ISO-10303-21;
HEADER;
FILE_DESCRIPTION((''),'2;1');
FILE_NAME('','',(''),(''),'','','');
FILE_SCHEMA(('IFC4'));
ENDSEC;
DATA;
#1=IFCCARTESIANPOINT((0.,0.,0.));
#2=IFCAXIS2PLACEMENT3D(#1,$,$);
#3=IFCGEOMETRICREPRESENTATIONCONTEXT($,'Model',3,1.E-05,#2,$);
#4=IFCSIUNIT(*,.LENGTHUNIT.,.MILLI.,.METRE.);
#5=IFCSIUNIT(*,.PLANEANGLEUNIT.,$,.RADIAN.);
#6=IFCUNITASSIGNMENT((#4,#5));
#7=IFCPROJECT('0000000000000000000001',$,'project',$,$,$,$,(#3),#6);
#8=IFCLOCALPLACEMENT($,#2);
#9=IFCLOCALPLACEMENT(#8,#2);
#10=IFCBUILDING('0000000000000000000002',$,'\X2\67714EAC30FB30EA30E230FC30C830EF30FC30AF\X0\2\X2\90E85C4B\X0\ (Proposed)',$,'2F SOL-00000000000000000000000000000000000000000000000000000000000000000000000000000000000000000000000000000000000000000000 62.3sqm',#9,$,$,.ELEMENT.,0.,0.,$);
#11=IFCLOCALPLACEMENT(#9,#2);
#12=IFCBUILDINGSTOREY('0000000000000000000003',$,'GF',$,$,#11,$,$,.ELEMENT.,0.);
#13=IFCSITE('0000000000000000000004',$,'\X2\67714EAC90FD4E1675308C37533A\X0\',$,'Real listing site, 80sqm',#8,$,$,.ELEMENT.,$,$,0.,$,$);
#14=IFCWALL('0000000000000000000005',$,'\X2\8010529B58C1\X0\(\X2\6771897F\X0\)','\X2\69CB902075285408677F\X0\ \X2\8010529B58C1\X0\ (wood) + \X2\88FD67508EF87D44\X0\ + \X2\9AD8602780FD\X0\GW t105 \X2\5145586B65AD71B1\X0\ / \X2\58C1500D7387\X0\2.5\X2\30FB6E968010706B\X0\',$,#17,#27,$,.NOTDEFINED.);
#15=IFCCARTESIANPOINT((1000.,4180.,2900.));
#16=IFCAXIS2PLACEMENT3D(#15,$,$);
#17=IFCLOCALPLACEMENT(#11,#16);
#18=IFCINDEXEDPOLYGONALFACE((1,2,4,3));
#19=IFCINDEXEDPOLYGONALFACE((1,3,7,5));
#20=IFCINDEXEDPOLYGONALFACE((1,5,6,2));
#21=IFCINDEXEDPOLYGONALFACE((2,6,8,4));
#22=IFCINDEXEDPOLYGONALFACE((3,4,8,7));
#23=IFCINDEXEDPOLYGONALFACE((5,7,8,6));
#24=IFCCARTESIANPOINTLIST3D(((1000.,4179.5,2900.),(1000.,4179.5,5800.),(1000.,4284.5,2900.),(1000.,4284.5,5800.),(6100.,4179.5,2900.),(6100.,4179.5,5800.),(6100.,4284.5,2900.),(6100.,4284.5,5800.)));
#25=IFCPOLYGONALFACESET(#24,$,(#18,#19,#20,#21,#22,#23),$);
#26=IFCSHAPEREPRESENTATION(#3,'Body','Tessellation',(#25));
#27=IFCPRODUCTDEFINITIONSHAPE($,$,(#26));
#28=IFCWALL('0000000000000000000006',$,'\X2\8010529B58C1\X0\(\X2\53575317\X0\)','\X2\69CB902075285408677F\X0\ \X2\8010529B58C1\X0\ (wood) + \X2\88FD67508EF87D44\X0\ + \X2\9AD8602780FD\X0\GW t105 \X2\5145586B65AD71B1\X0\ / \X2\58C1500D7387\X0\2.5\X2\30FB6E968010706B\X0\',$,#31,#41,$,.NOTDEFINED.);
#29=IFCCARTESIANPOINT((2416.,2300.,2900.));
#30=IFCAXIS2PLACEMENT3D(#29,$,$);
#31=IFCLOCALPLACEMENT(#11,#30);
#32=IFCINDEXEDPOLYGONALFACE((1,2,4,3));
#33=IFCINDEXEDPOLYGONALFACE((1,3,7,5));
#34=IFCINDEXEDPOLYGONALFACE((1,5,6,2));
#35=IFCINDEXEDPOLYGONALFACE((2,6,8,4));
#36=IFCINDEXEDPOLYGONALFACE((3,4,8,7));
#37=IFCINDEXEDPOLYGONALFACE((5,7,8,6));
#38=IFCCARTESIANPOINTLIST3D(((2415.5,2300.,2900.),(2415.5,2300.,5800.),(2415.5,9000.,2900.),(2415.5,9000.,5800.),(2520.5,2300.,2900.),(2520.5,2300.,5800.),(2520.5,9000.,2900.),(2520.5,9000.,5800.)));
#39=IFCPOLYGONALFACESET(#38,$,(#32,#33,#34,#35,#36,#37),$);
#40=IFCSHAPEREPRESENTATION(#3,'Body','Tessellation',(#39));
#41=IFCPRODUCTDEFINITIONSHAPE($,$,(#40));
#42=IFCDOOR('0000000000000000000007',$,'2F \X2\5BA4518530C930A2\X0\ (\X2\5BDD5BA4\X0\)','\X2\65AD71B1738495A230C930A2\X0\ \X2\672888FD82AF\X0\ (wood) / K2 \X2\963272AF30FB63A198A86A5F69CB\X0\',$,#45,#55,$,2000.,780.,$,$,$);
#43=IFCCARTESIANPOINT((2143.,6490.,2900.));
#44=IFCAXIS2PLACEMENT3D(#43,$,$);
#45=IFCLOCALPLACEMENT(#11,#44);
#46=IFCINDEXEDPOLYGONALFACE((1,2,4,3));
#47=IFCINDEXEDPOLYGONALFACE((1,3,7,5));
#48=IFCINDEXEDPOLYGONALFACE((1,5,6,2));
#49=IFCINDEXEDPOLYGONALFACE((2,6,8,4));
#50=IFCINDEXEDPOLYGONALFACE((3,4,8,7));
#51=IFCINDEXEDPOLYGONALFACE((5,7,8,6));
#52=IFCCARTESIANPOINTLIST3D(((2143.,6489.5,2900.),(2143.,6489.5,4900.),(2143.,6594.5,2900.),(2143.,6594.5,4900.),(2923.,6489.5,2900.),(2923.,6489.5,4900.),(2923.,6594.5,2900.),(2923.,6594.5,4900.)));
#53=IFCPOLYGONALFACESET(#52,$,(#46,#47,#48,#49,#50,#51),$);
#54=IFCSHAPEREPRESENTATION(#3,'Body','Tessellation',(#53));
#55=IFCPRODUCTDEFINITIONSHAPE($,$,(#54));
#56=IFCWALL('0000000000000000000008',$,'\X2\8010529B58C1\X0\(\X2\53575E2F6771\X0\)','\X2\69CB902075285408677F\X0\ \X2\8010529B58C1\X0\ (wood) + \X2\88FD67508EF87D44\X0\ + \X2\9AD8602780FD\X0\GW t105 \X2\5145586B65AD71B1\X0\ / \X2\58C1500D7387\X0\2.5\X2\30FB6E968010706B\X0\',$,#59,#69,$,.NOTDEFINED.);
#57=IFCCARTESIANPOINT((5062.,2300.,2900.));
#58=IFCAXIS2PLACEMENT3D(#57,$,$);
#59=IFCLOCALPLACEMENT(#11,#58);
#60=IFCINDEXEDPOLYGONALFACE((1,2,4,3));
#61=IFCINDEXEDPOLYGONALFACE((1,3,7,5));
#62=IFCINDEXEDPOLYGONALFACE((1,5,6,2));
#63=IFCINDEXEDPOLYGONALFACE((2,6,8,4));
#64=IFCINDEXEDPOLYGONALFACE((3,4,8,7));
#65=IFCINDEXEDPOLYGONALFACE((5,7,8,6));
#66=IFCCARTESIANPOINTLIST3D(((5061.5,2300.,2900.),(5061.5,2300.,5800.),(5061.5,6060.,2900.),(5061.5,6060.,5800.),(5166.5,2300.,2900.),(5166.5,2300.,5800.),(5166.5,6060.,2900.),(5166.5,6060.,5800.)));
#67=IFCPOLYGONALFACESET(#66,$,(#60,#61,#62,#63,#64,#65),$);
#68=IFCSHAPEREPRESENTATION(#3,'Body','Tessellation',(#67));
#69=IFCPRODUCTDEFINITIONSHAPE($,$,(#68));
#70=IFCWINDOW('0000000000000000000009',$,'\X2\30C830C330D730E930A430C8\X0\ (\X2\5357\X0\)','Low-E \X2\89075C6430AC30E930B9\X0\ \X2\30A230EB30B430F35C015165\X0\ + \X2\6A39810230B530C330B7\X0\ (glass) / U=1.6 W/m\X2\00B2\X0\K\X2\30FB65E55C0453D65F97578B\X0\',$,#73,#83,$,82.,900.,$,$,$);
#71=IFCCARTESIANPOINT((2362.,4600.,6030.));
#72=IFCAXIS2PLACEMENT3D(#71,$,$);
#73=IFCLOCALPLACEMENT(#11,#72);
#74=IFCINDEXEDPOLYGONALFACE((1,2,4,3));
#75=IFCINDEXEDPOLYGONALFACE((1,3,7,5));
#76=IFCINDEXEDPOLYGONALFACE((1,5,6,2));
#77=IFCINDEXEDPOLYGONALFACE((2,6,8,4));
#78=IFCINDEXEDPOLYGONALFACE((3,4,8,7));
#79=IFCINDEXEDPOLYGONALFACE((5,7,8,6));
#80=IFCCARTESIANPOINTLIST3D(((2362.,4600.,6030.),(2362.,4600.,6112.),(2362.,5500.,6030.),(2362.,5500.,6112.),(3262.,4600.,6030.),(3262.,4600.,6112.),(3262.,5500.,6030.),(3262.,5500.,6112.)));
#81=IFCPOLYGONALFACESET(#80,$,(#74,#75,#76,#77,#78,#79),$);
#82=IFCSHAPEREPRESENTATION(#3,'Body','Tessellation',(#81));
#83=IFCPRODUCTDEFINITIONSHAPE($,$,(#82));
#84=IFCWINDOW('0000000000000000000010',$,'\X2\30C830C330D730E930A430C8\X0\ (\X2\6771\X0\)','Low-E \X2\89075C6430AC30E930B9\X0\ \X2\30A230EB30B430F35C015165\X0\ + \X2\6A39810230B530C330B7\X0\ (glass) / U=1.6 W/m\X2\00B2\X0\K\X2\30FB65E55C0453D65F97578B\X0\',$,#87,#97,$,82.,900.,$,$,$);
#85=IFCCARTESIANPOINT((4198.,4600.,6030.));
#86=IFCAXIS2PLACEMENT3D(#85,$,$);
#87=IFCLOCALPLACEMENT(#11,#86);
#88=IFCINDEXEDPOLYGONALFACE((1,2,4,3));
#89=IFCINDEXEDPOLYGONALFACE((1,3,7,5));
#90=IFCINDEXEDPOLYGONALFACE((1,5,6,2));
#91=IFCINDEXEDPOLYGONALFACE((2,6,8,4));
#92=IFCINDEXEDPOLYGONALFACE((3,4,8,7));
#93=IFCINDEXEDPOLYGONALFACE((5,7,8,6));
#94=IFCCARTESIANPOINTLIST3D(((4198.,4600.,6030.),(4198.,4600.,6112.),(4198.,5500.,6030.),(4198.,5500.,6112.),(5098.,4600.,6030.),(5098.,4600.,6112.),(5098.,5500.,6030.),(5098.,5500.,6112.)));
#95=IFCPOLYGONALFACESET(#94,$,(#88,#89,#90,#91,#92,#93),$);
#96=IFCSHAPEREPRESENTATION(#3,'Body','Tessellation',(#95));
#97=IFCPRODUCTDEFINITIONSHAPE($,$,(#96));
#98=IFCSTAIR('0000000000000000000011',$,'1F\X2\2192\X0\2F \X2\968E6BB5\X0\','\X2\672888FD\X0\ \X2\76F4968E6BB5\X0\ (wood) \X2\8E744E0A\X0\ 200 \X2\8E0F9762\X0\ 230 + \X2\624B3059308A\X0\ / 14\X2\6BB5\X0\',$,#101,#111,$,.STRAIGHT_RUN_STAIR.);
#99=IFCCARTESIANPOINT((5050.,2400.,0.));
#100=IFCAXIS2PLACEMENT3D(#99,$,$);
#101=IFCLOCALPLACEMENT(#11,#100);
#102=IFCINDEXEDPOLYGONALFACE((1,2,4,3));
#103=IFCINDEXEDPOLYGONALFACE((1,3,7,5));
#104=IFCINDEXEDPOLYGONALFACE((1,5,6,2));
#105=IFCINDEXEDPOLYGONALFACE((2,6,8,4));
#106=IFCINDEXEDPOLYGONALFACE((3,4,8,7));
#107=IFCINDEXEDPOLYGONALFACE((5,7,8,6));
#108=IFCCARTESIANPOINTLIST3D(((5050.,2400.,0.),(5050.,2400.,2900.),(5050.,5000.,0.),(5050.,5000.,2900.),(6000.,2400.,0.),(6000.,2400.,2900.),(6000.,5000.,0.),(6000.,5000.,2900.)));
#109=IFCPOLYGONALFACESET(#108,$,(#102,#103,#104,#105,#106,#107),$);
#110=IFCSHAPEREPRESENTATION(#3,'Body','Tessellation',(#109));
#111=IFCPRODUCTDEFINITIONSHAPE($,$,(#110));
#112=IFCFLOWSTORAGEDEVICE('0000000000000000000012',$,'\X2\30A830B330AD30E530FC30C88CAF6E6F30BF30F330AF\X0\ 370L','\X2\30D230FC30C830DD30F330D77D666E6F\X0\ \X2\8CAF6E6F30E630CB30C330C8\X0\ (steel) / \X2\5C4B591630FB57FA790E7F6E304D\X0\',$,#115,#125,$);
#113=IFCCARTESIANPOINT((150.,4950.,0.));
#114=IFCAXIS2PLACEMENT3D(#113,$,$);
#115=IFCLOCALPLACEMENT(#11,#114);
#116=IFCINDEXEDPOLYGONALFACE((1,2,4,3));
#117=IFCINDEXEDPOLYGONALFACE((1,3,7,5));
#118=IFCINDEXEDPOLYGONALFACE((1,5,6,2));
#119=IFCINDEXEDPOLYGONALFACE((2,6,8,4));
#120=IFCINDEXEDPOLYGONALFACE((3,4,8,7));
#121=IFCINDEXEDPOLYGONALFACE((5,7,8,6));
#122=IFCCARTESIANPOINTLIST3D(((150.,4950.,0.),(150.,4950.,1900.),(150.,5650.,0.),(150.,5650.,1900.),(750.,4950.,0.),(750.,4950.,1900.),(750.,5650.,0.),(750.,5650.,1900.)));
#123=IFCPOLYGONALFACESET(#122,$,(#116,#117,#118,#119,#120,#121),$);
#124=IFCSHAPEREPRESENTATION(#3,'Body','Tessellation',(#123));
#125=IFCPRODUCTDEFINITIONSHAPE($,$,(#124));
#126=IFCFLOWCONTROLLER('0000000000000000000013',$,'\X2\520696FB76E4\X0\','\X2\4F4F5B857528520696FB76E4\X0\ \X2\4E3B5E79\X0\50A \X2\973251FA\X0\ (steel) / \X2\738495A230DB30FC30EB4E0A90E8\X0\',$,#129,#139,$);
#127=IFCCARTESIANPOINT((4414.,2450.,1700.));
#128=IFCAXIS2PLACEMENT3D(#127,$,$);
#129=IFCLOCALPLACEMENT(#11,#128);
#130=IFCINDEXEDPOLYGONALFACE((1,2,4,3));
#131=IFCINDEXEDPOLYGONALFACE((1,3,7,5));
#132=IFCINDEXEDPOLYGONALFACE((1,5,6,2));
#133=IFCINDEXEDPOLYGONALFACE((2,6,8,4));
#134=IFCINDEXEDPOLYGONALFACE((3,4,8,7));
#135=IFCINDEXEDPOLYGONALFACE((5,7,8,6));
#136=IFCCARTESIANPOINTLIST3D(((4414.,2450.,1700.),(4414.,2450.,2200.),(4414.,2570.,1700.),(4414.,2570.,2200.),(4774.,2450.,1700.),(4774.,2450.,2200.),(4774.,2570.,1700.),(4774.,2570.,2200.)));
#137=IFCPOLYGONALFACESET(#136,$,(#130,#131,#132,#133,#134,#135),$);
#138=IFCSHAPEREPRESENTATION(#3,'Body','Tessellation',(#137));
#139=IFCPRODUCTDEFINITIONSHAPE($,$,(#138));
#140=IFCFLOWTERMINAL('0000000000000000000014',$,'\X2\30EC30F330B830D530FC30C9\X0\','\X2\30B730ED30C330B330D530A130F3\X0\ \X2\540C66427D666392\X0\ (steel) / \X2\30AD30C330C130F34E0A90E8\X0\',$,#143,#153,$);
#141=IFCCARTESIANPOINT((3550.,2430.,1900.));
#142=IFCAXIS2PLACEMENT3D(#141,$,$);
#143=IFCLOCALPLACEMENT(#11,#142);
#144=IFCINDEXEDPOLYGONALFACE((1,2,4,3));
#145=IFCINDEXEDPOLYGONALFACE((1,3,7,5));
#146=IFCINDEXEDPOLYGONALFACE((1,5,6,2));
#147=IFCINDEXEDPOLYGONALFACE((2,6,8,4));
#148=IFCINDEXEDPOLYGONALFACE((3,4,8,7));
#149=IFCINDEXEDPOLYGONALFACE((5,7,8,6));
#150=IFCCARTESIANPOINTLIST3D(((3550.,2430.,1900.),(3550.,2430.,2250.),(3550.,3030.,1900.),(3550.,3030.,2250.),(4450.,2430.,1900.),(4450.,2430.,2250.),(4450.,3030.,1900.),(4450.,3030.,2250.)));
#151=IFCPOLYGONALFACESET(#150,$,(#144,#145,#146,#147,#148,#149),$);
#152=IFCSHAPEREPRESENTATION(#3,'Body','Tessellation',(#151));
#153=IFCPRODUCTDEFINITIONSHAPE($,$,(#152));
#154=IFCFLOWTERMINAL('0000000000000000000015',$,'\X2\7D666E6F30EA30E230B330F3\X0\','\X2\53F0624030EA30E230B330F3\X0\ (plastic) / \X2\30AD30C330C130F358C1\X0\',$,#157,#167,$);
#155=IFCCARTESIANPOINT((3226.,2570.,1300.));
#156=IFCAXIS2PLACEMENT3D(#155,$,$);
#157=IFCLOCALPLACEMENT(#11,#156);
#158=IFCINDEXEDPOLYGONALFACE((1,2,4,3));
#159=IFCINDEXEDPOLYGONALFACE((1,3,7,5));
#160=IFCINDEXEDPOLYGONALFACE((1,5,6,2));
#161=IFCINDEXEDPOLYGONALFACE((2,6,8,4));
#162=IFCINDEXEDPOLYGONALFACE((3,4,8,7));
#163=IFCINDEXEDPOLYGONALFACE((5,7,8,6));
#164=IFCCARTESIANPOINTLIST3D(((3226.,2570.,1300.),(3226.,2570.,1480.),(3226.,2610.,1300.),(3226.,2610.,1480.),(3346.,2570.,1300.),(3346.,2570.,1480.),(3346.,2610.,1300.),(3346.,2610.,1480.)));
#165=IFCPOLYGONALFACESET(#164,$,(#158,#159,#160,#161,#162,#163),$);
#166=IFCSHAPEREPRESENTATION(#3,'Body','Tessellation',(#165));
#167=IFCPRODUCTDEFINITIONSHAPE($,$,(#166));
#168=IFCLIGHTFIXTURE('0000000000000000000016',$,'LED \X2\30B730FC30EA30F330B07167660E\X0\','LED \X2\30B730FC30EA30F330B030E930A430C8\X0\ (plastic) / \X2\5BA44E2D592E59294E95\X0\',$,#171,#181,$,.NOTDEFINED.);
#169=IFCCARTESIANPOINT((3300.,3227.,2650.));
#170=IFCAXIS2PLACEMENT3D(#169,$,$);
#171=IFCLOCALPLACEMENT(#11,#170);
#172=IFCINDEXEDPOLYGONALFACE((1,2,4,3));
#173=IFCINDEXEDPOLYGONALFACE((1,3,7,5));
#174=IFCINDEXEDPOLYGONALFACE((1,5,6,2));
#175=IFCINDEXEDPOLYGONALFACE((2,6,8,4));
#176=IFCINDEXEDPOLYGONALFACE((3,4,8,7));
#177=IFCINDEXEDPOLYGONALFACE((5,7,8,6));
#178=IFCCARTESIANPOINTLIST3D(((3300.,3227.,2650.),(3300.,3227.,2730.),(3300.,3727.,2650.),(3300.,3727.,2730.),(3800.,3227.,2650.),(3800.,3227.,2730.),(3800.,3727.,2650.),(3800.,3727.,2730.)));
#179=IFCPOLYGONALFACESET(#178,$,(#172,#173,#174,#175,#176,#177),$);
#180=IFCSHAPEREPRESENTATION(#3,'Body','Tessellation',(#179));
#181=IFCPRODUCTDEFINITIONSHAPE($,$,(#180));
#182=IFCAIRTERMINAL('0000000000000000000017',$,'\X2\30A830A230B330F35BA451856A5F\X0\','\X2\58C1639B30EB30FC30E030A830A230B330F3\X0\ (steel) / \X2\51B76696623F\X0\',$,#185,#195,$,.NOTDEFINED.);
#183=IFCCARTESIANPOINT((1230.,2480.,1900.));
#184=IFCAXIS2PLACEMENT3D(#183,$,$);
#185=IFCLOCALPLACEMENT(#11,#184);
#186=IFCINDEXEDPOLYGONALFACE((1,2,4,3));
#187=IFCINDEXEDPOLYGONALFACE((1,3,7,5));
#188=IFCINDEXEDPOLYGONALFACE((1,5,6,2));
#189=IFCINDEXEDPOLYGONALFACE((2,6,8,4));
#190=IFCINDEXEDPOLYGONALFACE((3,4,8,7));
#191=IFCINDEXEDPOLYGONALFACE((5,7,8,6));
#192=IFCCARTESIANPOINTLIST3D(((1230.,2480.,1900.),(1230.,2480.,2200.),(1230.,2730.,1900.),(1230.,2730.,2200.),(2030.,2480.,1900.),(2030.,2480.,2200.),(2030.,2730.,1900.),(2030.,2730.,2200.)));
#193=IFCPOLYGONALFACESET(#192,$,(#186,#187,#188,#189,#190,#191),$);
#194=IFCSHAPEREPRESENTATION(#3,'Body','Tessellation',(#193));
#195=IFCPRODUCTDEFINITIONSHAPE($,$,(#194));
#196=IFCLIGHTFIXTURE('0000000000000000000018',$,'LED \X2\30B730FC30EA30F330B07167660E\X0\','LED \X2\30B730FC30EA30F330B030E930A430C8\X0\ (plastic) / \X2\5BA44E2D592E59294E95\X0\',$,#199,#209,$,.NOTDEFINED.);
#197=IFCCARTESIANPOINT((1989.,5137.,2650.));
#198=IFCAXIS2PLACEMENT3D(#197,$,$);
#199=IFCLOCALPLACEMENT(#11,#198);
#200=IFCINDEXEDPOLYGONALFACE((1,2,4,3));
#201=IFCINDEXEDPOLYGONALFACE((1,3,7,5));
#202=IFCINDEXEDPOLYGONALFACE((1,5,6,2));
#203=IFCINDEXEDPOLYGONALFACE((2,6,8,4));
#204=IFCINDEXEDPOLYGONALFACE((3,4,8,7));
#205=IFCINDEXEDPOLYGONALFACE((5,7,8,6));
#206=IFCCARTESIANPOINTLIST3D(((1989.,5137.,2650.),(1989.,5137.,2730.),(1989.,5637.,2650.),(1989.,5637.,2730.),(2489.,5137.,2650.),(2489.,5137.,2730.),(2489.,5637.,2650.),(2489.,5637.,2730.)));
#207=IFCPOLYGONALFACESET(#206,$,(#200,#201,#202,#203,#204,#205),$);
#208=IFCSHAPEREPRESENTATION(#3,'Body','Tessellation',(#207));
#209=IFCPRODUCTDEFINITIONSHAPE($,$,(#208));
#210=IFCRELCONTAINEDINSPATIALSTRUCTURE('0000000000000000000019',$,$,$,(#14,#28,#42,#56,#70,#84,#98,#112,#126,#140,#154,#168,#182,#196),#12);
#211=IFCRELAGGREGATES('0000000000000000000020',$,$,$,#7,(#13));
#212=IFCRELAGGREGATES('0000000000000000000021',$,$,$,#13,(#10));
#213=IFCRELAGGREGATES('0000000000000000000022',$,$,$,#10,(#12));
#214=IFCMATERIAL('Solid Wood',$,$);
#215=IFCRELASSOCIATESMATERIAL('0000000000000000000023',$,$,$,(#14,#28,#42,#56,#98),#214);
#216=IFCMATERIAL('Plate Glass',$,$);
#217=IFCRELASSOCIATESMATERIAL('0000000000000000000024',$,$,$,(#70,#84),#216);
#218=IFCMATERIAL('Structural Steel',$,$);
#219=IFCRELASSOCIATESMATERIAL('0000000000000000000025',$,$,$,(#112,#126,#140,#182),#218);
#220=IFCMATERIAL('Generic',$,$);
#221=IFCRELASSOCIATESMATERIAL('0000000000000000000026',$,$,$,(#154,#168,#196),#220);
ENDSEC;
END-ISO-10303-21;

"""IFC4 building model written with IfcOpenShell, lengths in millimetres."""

from ifc_helpers import new_model, si_unit, frame, frame_2d, origin, place, context, project, spatial, rectangle, extrude, material, element, fill, save


model = new_model("IFC4")

# Units and contexts
model_context = context("Model", 3, precision=1e-05, world=origin())
ifc_project = project(units=[si_unit("LENGTHUNIT", "METRE", prefix="MILLI"), si_unit("PLANEANGLEUNIT", "RADIAN")], contexts=[model_context])

# Site, building, storey
site_placement = place(None, origin())
site = spatial("IfcSite", under=ifc_project, at=site_placement, Name="東京都世田谷区", ObjectType="Real listing site, 80sqm", CompositionType="ELEMENT", RefElevation=0.0)
building_placement = place(site_placement, origin())
building = spatial("IfcBuilding", under=site, at=building_placement, Name="東京・リモートワーク2部屋 (Proposed)", ObjectType="2F SOL-00000000000000000000000000000000000000000000000000000000000000000000000000000000000000000000000000000000000000000000 62.3sqm", CompositionType="ELEMENT", ElevationOfRefHeight=0.0, ElevationOfTerrain=0.0)
storey_placement = place(building_placement, origin())
storey = spatial("IfcBuildingStorey", under=building, at=storey_placement, Name="GF", CompositionType="ELEMENT", Elevation=0.0)

# Shared definitions
ifc_material_1 = material(Name="Solid Wood")

# Wall
wall_1_placement = place(storey_placement, frame((1000.0, 4180.0, 2900.0)))
element("IfcWall", 1, at=wall_1_placement, inside=storey, material=ifc_material_1, Name="耐力壁(東西)", Description="構造用合板 耐力壁 (wood) + 製材軸組 + 高性能GW t105 充填断熱 / 壁倍率2.5・準耐火", PredefinedType="NOTDEFINED", context=model_context, shape_type="SweptSolid", body=[
    extrude(rectangle(XDim=5100.0, YDim=105.0, at=frame_2d((2550.0, 52.0))), frame((1000.0, 4180.0, 2900.0)), (0.0, 0.0, 1.0), 2900.0),
])

# Wall, opening, door
wall_2_placement = place(storey_placement, frame((2416.0, 2300.0, 2900.0)))
wall_2 = element("IfcWall", 2, at=wall_2_placement, inside=storey, material=ifc_material_1, Name="耐力壁(南北)", Description="構造用合板 耐力壁 (wood) + 製材軸組 + 高性能GW t105 充填断熱 / 壁倍率2.5・準耐火", PredefinedType="NOTDEFINED", context=model_context, shape_type="SweptSolid", body=[
    extrude(rectangle(XDim=105.0, YDim=6700.0, at=frame_2d((52.0, 3350.0))), frame((2416.0, 2300.0, 2900.0)), (0.0, 0.0, 1.0), 2900.0),
])
opening_placement = place(storey_placement, frame((2143.0, 6490.0, 2900.0)))
opening = element("IfcOpeningElement", 3, at=opening_placement, cuts=wall_2, PredefinedType="NOTDEFINED", context=model_context, shape_type="SweptSolid", body=[
    extrude(rectangle(XDim=780.0, YDim=105.0, at=frame_2d((390.0, 52.0))), frame((2143.0, 6490.0, 2900.0)), (0.0, 0.0, 1.0), 2000.0),
])
door_placement = place(storey_placement, frame((2143.0, 6490.0, 2900.0)))
door = element("IfcDoor", 4, at=door_placement, inside=storey, material=ifc_material_1, Name="2F 室内ドア (寝室)", Description="断熱玄関ドア 木製芯 (wood) / K2 防犯・採風機構", OverallHeight=2000.0, OverallWidth=780.0, context=model_context, shape_type="SweptSolid", body=[
    extrude(rectangle(XDim=780.0, YDim=105.0, at=frame_2d((390.0, 52.0))), frame((2143.0, 6490.0, 2900.0)), (0.0, 0.0, 1.0), 2000.0),
])
fill(opening, door)

# Wall
wall_3_placement = place(storey_placement, frame((5062.0, 2300.0, 2900.0)))
element("IfcWall", 5, at=wall_3_placement, inside=storey, material=ifc_material_1, Name="耐力壁(南帯東)", Description="構造用合板 耐力壁 (wood) + 製材軸組 + 高性能GW t105 充填断熱 / 壁倍率2.5・準耐火", PredefinedType="NOTDEFINED", context=model_context, shape_type="SweptSolid", body=[
    extrude(rectangle(XDim=105.0, YDim=3760.0, at=frame_2d((52.0, 1880.0))), frame((5062.0, 2300.0, 2900.0)), (0.0, 0.0, 1.0), 2900.0),
])

# Windows
ifc_material_2 = material(Name="Plate Glass")
window_1_placement = place(storey_placement, frame((2362.0, 4600.0, 6030.0)))
element("IfcWindow", 6, at=window_1_placement, inside=storey, material=ifc_material_2, Name="トップライト (南)", Description="Low-E 複層ガラス アルゴン封入 + 樹脂サッシ (glass) / U=1.6 W/m²K・日射取得型", OverallHeight=82.0, OverallWidth=900.0, context=model_context, shape_type="SweptSolid", body=[
    extrude(rectangle(XDim=900.0, YDim=900.0, at=frame_2d((450.0, 450.0))), frame((2362.0, 4600.0, 6030.0)), (0.0, 0.0, 1.0), 82.0),
])
window_2_placement = place(storey_placement, frame((4198.0, 4600.0, 6030.0)))
element("IfcWindow", 7, at=window_2_placement, inside=storey, material=ifc_material_2, Name="トップライト (東)", Description="Low-E 複層ガラス アルゴン封入 + 樹脂サッシ (glass) / U=1.6 W/m²K・日射取得型", OverallHeight=82.0, OverallWidth=900.0, context=model_context, shape_type="SweptSolid", body=[
    extrude(rectangle(XDim=900.0, YDim=900.0, at=frame_2d((450.0, 450.0))), frame((4198.0, 4600.0, 6030.0)), (0.0, 0.0, 1.0), 82.0),
])

# Stair
stair_placement = place(storey_placement, frame((5050.0, 2400.0, 0.0)))
element("IfcStair", 8, at=stair_placement, inside=storey, material=ifc_material_1, Name="1F→2F 階段", Description="木製 直階段 (wood) 蹴上 200 踏面 230 + 手すり / 14段", PredefinedType="STRAIGHT_RUN_STAIR", context=model_context, shape_type="SweptSolid", body=[
    extrude(rectangle(XDim=950.0, YDim=2600.0, at=frame_2d((475.0, 1300.0))), frame((5050.0, 2400.0, 0.0)), (0.0, 0.0, 1.0), 2900.0),
])

# Flow storage device
ifc_material_3 = material(Name="Structural Steel")
flow_storage_device_placement = place(storey_placement, frame((150.0, 4950.0, 0.0)))
element("IfcFlowStorageDevice", 9, at=flow_storage_device_placement, inside=storey, material=ifc_material_3, Name="エコキュート貯湯タンク 370L", Description="ヒートポンプ給湯 貯湯ユニット (steel) / 屋外・基礎置き", context=model_context, shape_type="SweptSolid", body=[
    extrude(rectangle(XDim=600.0, YDim=700.0, at=frame_2d((300.0, 350.0))), frame((150.0, 4950.0, 0.0)), (0.0, 0.0, 1.0), 1900.0),
])

# Flow controller
flow_controller_placement = place(storey_placement, frame((4414.0, 2450.0, 1700.0)))
element("IfcFlowController", 10, at=flow_controller_placement, inside=storey, material=ifc_material_3, Name="分電盤", Description="住宅用分電盤 主幹50A 露出 (steel) / 玄関ホール上部", context=model_context, shape_type="SweptSolid", body=[
    extrude(rectangle(XDim=360.0, YDim=120.0, at=frame_2d((180.0, 60.0))), frame((4414.0, 2450.0, 1700.0)), (0.0, 0.0, 1.0), 500.0),
])

# Flow terminals
flow_terminal_1_placement = place(storey_placement, frame((3550.0, 2430.0, 1900.0)))
element("IfcFlowTerminal", 11, at=flow_terminal_1_placement, inside=storey, material=ifc_material_3, Name="レンジフード", Description="シロッコファン 同時給排 (steel) / キッチン上部", context=model_context, shape_type="SweptSolid", body=[
    extrude(rectangle(XDim=900.0, YDim=600.0, at=frame_2d((450.0, 300.0))), frame((3550.0, 2430.0, 1900.0)), (0.0, 0.0, 1.0), 350.0),
])
ifc_material_4 = material(Name="Generic")
flow_terminal_2_placement = place(storey_placement, frame((3226.0, 2570.0, 1300.0)))
element("IfcFlowTerminal", 12, at=flow_terminal_2_placement, inside=storey, material=ifc_material_4, Name="給湯リモコン", Description="台所リモコン (plastic) / キッチン壁", context=model_context, shape_type="SweptSolid", body=[
    extrude(rectangle(XDim=120.0, YDim=40.0, at=frame_2d((60.0, 20.0))), frame((3226.0, 2570.0, 1300.0)), (0.0, 0.0, 1.0), 180.0),
])

# Light fixture
light_fixture_1_placement = place(storey_placement, frame((3300.0, 3227.0, 2650.0)))
element("IfcLightFixture", 13, at=light_fixture_1_placement, inside=storey, material=ifc_material_4, Name="LED シーリング照明", Description="LED シーリングライト (plastic) / 室中央天井", PredefinedType="NOTDEFINED", context=model_context, shape_type="SweptSolid", body=[
    extrude(rectangle(XDim=500.0, YDim=500.0, at=frame_2d((250.0, 250.0))), frame((3300.0, 3227.0, 2650.0)), (0.0, 0.0, 1.0), 80.0),
])

# Air terminal
air_terminal_1_placement = place(storey_placement, frame((1230.0, 2480.0, 1900.0)))
element("IfcAirTerminal", 14, at=air_terminal_1_placement, inside=storey, material=ifc_material_3, Name="エアコン室内機", Description="壁掛ルームエアコン (steel) / 冷暖房", PredefinedType="NOTDEFINED", context=model_context, shape_type="SweptSolid", body=[
    extrude(rectangle(XDim=800.0, YDim=250.0, at=frame_2d((400.0, 125.0))), frame((1230.0, 2480.0, 1900.0)), (0.0, 0.0, 1.0), 300.0),
])

# Light fixture
light_fixture_2_placement = place(storey_placement, frame((1989.0, 5137.0, 2650.0)))
element("IfcLightFixture", 15, at=light_fixture_2_placement, inside=storey, material=ifc_material_4, Name="LED シーリング照明", Description="LED シーリングライト (plastic) / 室中央天井", PredefinedType="NOTDEFINED", context=model_context, shape_type="SweptSolid", body=[
    extrude(rectangle(XDim=500.0, YDim=500.0, at=frame_2d((250.0, 250.0))), frame((1989.0, 5137.0, 2650.0)), (0.0, 0.0, 1.0), 80.0),
])

save(model, "model.ifc")
